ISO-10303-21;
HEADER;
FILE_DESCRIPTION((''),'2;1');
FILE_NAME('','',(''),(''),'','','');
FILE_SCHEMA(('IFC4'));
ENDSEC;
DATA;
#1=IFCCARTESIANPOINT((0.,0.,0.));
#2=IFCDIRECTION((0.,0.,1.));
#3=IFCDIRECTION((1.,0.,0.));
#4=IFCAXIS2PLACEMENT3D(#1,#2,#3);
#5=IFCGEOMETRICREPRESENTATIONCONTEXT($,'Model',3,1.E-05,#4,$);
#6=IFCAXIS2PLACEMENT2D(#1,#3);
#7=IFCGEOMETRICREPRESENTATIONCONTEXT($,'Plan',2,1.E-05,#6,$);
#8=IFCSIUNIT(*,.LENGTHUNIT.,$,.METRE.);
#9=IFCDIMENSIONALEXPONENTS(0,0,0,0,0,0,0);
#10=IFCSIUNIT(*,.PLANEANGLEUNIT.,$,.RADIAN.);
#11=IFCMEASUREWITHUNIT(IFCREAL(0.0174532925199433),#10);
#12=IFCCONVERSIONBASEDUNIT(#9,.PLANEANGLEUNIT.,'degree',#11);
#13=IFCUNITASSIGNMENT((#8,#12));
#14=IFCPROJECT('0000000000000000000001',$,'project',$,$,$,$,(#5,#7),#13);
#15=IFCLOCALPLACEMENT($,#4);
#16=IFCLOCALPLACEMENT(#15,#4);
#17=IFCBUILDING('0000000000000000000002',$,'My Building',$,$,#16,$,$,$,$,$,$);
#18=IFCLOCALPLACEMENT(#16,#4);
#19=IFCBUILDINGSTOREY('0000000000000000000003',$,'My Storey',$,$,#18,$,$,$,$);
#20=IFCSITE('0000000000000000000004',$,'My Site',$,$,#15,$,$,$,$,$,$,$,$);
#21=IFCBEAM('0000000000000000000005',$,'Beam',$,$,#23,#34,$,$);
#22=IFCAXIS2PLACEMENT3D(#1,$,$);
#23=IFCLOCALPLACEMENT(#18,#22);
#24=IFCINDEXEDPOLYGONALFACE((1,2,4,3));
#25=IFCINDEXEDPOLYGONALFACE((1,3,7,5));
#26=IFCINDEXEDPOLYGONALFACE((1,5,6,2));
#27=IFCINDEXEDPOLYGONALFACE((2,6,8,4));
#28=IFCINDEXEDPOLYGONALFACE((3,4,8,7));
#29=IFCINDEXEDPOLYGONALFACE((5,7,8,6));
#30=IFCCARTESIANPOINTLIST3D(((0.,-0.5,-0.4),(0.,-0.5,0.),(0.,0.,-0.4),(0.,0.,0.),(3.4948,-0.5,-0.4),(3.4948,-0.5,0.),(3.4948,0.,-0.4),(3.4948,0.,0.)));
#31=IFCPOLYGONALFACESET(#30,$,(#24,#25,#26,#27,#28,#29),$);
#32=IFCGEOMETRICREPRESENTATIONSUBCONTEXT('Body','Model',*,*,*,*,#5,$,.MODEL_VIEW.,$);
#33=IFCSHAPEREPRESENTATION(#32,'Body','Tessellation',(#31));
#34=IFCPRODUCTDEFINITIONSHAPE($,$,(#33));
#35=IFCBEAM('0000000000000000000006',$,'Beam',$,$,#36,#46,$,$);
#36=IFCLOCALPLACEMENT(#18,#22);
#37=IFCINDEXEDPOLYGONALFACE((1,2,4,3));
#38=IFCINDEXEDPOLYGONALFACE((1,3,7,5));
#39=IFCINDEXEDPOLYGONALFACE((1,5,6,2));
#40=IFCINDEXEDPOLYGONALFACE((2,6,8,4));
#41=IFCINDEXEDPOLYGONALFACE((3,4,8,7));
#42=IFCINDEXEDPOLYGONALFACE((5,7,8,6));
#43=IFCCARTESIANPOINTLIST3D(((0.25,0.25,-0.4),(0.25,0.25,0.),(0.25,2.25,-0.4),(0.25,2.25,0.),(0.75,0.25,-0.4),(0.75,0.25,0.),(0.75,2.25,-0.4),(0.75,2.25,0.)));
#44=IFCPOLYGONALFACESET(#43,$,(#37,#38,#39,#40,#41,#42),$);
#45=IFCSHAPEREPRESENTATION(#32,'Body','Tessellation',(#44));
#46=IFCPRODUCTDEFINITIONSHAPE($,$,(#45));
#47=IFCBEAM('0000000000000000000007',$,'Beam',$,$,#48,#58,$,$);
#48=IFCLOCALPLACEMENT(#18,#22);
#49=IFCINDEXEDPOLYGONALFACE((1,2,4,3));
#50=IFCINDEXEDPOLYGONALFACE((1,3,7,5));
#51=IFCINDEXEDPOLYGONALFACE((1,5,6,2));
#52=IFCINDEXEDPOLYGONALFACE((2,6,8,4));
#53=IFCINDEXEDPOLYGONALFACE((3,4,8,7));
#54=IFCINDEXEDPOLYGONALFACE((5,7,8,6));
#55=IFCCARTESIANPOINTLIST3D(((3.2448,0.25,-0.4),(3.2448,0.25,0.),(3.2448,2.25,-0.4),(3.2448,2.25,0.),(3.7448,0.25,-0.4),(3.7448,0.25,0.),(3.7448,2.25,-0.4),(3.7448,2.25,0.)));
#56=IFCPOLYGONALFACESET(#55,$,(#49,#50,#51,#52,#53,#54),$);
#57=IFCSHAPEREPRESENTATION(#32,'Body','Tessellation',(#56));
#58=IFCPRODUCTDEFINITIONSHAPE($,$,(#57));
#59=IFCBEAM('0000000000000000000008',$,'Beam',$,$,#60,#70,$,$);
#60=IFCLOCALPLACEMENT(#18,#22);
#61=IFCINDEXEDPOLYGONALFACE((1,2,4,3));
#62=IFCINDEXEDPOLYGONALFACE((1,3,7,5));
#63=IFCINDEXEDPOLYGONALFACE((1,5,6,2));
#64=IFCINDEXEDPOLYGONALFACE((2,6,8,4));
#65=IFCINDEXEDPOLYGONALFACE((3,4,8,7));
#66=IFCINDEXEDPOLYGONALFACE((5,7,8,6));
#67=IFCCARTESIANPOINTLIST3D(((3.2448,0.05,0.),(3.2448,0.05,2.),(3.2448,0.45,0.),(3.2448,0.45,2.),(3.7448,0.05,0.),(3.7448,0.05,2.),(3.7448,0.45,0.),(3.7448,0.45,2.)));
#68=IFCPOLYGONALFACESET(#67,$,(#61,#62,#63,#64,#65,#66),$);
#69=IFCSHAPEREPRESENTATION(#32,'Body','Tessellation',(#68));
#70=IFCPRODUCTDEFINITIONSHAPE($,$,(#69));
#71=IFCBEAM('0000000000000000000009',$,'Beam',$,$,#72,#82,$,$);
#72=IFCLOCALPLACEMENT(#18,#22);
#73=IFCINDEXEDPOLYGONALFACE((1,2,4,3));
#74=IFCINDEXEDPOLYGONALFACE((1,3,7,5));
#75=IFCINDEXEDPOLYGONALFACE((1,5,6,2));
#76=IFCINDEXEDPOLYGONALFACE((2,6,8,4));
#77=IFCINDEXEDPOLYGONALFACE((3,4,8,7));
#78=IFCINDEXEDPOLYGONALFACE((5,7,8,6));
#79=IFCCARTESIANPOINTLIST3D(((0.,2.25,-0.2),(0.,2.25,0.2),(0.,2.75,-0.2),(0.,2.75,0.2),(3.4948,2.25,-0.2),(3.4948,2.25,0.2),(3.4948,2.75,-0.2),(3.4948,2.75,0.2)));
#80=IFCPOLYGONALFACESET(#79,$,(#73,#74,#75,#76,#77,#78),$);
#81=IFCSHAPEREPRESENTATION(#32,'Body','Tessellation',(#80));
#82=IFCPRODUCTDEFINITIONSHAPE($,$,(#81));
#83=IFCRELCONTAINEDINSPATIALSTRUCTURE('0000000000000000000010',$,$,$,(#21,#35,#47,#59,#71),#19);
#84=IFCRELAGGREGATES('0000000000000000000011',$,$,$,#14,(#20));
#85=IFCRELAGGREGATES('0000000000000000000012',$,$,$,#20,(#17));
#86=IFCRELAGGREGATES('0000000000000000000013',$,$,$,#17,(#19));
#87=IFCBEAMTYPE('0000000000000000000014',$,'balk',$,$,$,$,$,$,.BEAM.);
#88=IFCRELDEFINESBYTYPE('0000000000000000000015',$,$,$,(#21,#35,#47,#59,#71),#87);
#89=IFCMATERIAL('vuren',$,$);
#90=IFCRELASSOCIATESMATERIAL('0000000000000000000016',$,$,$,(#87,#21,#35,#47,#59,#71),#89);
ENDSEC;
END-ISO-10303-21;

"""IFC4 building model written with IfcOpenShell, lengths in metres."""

from ifc_helpers import new_model, entity, si_unit, converted_unit, frame, frame_2d, origin_with_axes, place, context, subcontext, project, spatial, rectangle, extrude, material, material_profile, profile_set, profile_usage, type_object, element, save


model = new_model("IFC4")

# Units and contexts
model_context = context("Model", 3, precision=1e-05, world=origin_with_axes())
plan_context = context("Plan", 2, precision=1e-05, world=frame_2d((0.0, 0.0, 0.0), x_axis=(1.0, 0.0, 0.0)))
body_context = subcontext(model_context, "Body", "Model", "MODEL_VIEW")
ifc_project = project(units=[si_unit("LENGTHUNIT", "METRE"), converted_unit("PLANEANGLEUNIT", "degree", entity("IfcReal", 0.0174532925199433), si_unit("PLANEANGLEUNIT", "RADIAN"), dimensions=[0, 0, 0, 0, 0, 0, 0])], contexts=[model_context, plan_context])

# Site, building, storey
site_placement = place(None, origin_with_axes())
site = spatial("IfcSite", under=ifc_project, at=site_placement, Name="My Site")
building_placement = place(site_placement, origin_with_axes())
building = spatial("IfcBuilding", under=site, at=building_placement, Name="My Building")
storey_placement = place(building_placement, origin_with_axes())
storey = spatial("IfcBuildingStorey", under=building, at=storey_placement, Name="My Storey")

# Beams
ifc_material = material(Name="vuren")
ifc_material_profile = material_profile(ifc_material, rectangle(XDim=0.5, YDim=0.4))
ifc_profile_set = profile_set([ifc_material_profile])
ifc_profile_usage_1 = profile_usage(ifc_profile_set)
beam_type = type_object("IfcBeamType", Name="balk", PredefinedType="BEAM", material=ifc_profile_set)
beam_1_placement = place(storey_placement, frame((0.0, -0.25, -0.2), z_axis=(1.0, 0.0, 0.0), x_axis=(0.0, 1.0, 0.0)))
element("IfcBeam", 1, at=beam_1_placement, inside=storey, type_object=beam_type, material=ifc_profile_usage_1, Name="Beam", context=body_context, shape_type="SweptSolid", body=[
    extrude(rectangle(XDim=0.5, YDim=0.4), None, (0.0, 0.0, 1.0), 3.4948),
])
ifc_profile_usage_2 = profile_usage(ifc_profile_set)
beam_2_placement = place(storey_placement, frame((0.5, 0.25, -0.2), z_axis=(0.0, 1.0, 0.0), x_axis=(-1.0, 0.0, 0.0)))
element("IfcBeam", 2, at=beam_2_placement, inside=storey, type_object=beam_type, material=ifc_profile_usage_2, Name="Beam", context=body_context, shape_type="SweptSolid", body=[
    extrude(rectangle(XDim=0.5, YDim=0.4), None, (0.0, 0.0, 1.0), 2.0),
])
ifc_profile_usage_3 = profile_usage(ifc_profile_set)
beam_3_placement = place(storey_placement, frame((3.4948, 0.25, -0.2), z_axis=(0.0, 1.0, 0.0), x_axis=(-1.0, 0.0, 0.0)))
element("IfcBeam", 3, at=beam_3_placement, inside=storey, type_object=beam_type, material=ifc_profile_usage_3, Name="Beam", context=body_context, shape_type="SweptSolid", body=[
    extrude(rectangle(XDim=0.5, YDim=0.4), None, (0.0, 0.0, 1.0), 2.0),
])
ifc_profile_usage_4 = profile_usage(ifc_profile_set)
beam_4_placement = place(storey_placement, frame((3.4948, 0.25, 0.0), z_axis=(0.0, 0.0, 1.0), x_axis=(1.0, 0.0, 0.0)))
element("IfcBeam", 4, at=beam_4_placement, inside=storey, type_object=beam_type, material=ifc_profile_usage_4, Name="Beam", context=body_context, shape_type="SweptSolid", body=[
    extrude(rectangle(XDim=0.5, YDim=0.4), None, (0.0, 0.0, 1.0), 2.0),
])
ifc_profile_usage_5 = profile_usage(ifc_profile_set)
beam_5_placement = place(storey_placement, frame((0.0, 2.5, 0.0), z_axis=(1.0, 0.0, 0.0), x_axis=(0.0, 1.0, 0.0)))
element("IfcBeam", 5, at=beam_5_placement, inside=storey, type_object=beam_type, material=ifc_profile_usage_5, Name="Beam", context=body_context, shape_type="SweptSolid", body=[
    extrude(rectangle(XDim=0.5, YDim=0.4), None, (0.0, 0.0, 1.0), 3.4948),
])

save(model, "model.ifc")
